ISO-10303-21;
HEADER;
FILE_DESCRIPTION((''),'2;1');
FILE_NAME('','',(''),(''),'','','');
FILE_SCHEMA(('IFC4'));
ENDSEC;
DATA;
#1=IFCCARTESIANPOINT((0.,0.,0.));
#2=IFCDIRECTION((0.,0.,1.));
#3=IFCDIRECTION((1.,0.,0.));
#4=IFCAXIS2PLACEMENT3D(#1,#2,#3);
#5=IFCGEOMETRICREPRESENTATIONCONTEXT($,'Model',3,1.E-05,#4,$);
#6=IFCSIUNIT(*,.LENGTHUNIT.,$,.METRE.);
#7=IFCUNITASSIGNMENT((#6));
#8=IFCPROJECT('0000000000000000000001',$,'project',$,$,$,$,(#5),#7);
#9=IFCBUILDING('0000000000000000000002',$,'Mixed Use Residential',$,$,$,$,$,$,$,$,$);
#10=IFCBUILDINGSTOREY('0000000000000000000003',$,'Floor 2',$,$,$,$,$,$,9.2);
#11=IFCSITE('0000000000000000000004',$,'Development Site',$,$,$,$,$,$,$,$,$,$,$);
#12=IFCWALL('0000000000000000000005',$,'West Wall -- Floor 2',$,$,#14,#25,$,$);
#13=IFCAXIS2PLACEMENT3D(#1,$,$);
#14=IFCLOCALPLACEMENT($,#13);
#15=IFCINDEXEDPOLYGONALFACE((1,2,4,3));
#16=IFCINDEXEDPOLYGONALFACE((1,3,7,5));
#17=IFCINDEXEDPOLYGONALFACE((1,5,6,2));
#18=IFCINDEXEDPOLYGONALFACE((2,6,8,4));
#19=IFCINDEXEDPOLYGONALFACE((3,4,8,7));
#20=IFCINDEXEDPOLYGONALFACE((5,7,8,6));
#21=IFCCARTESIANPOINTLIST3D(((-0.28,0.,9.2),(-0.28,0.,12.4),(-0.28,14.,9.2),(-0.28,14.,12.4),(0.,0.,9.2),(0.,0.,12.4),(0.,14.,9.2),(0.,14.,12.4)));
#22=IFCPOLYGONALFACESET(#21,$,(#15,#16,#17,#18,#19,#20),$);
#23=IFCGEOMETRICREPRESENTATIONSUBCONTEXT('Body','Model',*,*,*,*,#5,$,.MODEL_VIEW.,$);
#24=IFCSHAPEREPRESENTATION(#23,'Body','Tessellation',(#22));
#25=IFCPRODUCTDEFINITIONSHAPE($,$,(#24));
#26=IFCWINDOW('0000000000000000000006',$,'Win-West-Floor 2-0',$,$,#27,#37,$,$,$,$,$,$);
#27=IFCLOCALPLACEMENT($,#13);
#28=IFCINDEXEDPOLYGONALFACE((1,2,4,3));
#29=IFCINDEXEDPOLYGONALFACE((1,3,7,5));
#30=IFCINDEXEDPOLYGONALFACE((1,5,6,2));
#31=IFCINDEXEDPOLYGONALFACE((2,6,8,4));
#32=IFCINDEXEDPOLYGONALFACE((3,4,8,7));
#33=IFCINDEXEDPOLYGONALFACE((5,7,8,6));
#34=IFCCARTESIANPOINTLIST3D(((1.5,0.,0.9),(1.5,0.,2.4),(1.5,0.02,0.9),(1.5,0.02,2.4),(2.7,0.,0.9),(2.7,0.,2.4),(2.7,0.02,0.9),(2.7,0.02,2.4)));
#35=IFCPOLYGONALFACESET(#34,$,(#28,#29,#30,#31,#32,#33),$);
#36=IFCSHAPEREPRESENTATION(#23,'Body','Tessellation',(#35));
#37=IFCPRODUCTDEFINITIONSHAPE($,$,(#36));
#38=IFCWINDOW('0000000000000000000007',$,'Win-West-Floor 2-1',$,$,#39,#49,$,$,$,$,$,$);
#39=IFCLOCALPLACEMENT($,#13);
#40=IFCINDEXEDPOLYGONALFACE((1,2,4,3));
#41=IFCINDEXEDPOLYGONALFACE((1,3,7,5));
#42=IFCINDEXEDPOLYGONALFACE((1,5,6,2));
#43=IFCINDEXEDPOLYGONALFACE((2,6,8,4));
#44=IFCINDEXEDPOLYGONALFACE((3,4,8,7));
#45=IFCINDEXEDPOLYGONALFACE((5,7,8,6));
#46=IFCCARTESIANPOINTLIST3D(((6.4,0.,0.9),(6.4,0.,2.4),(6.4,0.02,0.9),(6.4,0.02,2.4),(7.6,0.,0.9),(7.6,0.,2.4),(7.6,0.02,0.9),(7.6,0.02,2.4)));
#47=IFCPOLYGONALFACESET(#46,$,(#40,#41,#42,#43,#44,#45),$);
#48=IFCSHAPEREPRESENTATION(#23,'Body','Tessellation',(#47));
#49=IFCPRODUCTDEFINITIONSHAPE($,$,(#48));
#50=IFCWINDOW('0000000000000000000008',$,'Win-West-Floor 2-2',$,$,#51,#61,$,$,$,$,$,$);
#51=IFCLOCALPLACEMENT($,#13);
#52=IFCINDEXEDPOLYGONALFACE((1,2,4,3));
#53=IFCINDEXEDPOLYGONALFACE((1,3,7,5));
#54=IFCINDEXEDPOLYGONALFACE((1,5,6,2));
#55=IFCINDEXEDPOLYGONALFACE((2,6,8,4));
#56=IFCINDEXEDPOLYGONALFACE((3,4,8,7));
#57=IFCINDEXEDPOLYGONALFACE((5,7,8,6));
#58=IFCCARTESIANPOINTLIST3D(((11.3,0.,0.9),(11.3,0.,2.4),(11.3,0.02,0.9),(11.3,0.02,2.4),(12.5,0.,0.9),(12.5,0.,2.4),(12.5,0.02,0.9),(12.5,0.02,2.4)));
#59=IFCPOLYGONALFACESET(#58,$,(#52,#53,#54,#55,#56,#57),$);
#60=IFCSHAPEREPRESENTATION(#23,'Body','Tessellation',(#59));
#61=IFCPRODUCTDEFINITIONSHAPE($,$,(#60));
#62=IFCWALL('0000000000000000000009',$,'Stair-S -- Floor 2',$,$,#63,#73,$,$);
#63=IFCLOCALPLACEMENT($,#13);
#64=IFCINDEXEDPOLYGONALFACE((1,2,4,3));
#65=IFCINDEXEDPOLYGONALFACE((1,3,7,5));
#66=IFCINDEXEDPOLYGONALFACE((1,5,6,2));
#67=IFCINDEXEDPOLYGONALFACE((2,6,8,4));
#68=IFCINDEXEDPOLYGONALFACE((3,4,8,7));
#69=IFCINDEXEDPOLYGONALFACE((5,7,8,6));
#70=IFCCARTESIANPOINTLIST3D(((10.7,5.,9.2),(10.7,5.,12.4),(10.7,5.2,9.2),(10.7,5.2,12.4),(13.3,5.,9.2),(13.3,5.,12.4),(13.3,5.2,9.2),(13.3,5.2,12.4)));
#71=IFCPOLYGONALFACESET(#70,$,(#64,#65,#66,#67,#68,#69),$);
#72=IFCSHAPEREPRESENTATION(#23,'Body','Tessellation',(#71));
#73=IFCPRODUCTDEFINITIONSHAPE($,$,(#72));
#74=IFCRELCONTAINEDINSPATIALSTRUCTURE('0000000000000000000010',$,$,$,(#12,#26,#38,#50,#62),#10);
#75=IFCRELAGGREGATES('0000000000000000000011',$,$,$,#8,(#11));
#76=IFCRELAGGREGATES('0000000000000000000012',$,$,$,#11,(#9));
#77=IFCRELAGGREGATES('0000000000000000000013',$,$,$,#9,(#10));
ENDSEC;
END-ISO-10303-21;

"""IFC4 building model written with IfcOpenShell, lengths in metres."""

from ifc_helpers import new_model, si_unit, frame, origin_with_axes, place, context, subcontext, project, spatial, indexed_curve, outline, extrude, element, fill, save


model = new_model("IFC4")

# Units and contexts
model_context = context("Model", 3, precision=1e-05, world=origin_with_axes())
body_context = subcontext(model_context, "Body", "Model", "MODEL_VIEW")
ifc_project = project(units=[si_unit("LENGTHUNIT", "METRE")], contexts=[model_context])

# Site, building, storey
site = spatial("IfcSite", under=ifc_project, Name="Development Site")
building = spatial("IfcBuilding", under=site, Name="Mixed Use Residential")
storey = spatial("IfcBuildingStorey", under=building, Name="Floor 2", Elevation=9.2)

# Wall, openings, windows
wall_1_placement = place(None, frame((0.0, 0.0, 9.2), z_axis=(0.0, 0.0, 1.0), x_axis=(0.0, 1.0, 0.0)))
wall_1 = element("IfcWall", 1, at=wall_1_placement, inside=storey, Name="West Wall -- Floor 2", context=body_context, shape_type="SweptSolid", body=[
    extrude(outline(indexed_curve([(0.0, 0.0), (0.0, 0.28), (14.0, 0.28), (14.0, 0.0), (0.0, 0.0)], self_intersect=False)), origin_with_axes(), (0.0, 0.0, 1.0), 3.2),
])
opening_1_placement = place(wall_1_placement, frame((0.0, -1.5, -8.3), z_axis=(0.0, 0.0, 1.0), x_axis=(0.0, -1.0, 0.0)))
opening_1 = element("IfcOpeningElement", 2, at=opening_1_placement, cuts=wall_1, context=body_context, shape_type="SweptSolid", body=[
    extrude(outline(indexed_curve([(0.0, 0.0), (0.0, 0.28), (1.2, 0.28), (1.2, 0.0), (0.0, 0.0)], self_intersect=False)), origin_with_axes(), (0.0, 0.0, 1.0), 1.5),
])
opening_2_placement = place(wall_1_placement, frame((0.0, -6.4, -8.3), z_axis=(0.0, 0.0, 1.0), x_axis=(0.0, -1.0, 0.0)))
opening_2 = element("IfcOpeningElement", 3, at=opening_2_placement, cuts=wall_1, context=body_context, shape_type="SweptSolid", body=[
    extrude(outline(indexed_curve([(0.0, 0.0), (0.0, 0.28), (1.2, 0.28), (1.2, 0.0), (0.0, 0.0)], self_intersect=False)), origin_with_axes(), (0.0, 0.0, 1.0), 1.5),
])
opening_3_placement = place(wall_1_placement, frame((0.0, -11.3, -8.3), z_axis=(0.0, 0.0, 1.0), x_axis=(0.0, -1.0, 0.0)))
opening_3 = element("IfcOpeningElement", 4, at=opening_3_placement, cuts=wall_1, context=body_context, shape_type="SweptSolid", body=[
    extrude(outline(indexed_curve([(0.0, 0.0), (0.0, 0.28), (1.2, 0.28), (1.2, 0.0), (0.0, 0.0)], self_intersect=False)), origin_with_axes(), (0.0, 0.0, 1.0), 1.5),
])
window_1_placement = place(None, frame((1.5, 0.0, 0.9), z_axis=(0.0, 0.0, 1.0), x_axis=(1.0, 0.0, 0.0)))
window_1 = element("IfcWindow", 5, at=window_1_placement, inside=storey, Name="Win-West-Floor 2-0", context=body_context, shape_type="SweptSolid", body=[
    extrude(outline(indexed_curve([(0.0, 0.0), (0.0, 0.02), (1.2, 0.02), (1.2, 0.0), (0.0, 0.0)], self_intersect=False)), origin_with_axes(), (0.0, 0.0, 1.0), 1.5),
])
fill(opening_1, window_1)
window_2_placement = place(None, frame((6.4, 0.0, 0.9), z_axis=(0.0, 0.0, 1.0), x_axis=(1.0, 0.0, 0.0)))
window_2 = element("IfcWindow", 6, at=window_2_placement, inside=storey, Name="Win-West-Floor 2-1", context=body_context, shape_type="SweptSolid", body=[
    extrude(outline(indexed_curve([(0.0, 0.0), (0.0, 0.02), (1.2, 0.02), (1.2, 0.0), (0.0, 0.0)], self_intersect=False)), origin_with_axes(), (0.0, 0.0, 1.0), 1.5),
])
fill(opening_2, window_2)
window_3_placement = place(None, frame((11.3, 0.0, 0.9), z_axis=(0.0, 0.0, 1.0), x_axis=(1.0, 0.0, 0.0)))
window_3 = element("IfcWindow", 7, at=window_3_placement, inside=storey, Name="Win-West-Floor 2-2", context=body_context, shape_type="SweptSolid", body=[
    extrude(outline(indexed_curve([(0.0, 0.0), (0.0, 0.02), (1.2, 0.02), (1.2, 0.0), (0.0, 0.0)], self_intersect=False)), origin_with_axes(), (0.0, 0.0, 1.0), 1.5),
])
fill(opening_3, window_3)

# Wall
wall_2_placement = place(None, frame((10.7, 5.0, 9.2), z_axis=(0.0, 0.0, 1.0), x_axis=(1.0, 0.0, 0.0)))
element("IfcWall", 8, at=wall_2_placement, inside=storey, Name="Stair-S -- Floor 2", context=body_context, shape_type="SweptSolid", body=[
    extrude(outline(indexed_curve([(0.0, 0.0), (0.0, 0.2), (2.6, 0.2), (2.6, 0.0), (0.0, 0.0)], self_intersect=False)), origin_with_axes(), (0.0, 0.0, 1.0), 3.2),
])

save(model, "model.ifc")
